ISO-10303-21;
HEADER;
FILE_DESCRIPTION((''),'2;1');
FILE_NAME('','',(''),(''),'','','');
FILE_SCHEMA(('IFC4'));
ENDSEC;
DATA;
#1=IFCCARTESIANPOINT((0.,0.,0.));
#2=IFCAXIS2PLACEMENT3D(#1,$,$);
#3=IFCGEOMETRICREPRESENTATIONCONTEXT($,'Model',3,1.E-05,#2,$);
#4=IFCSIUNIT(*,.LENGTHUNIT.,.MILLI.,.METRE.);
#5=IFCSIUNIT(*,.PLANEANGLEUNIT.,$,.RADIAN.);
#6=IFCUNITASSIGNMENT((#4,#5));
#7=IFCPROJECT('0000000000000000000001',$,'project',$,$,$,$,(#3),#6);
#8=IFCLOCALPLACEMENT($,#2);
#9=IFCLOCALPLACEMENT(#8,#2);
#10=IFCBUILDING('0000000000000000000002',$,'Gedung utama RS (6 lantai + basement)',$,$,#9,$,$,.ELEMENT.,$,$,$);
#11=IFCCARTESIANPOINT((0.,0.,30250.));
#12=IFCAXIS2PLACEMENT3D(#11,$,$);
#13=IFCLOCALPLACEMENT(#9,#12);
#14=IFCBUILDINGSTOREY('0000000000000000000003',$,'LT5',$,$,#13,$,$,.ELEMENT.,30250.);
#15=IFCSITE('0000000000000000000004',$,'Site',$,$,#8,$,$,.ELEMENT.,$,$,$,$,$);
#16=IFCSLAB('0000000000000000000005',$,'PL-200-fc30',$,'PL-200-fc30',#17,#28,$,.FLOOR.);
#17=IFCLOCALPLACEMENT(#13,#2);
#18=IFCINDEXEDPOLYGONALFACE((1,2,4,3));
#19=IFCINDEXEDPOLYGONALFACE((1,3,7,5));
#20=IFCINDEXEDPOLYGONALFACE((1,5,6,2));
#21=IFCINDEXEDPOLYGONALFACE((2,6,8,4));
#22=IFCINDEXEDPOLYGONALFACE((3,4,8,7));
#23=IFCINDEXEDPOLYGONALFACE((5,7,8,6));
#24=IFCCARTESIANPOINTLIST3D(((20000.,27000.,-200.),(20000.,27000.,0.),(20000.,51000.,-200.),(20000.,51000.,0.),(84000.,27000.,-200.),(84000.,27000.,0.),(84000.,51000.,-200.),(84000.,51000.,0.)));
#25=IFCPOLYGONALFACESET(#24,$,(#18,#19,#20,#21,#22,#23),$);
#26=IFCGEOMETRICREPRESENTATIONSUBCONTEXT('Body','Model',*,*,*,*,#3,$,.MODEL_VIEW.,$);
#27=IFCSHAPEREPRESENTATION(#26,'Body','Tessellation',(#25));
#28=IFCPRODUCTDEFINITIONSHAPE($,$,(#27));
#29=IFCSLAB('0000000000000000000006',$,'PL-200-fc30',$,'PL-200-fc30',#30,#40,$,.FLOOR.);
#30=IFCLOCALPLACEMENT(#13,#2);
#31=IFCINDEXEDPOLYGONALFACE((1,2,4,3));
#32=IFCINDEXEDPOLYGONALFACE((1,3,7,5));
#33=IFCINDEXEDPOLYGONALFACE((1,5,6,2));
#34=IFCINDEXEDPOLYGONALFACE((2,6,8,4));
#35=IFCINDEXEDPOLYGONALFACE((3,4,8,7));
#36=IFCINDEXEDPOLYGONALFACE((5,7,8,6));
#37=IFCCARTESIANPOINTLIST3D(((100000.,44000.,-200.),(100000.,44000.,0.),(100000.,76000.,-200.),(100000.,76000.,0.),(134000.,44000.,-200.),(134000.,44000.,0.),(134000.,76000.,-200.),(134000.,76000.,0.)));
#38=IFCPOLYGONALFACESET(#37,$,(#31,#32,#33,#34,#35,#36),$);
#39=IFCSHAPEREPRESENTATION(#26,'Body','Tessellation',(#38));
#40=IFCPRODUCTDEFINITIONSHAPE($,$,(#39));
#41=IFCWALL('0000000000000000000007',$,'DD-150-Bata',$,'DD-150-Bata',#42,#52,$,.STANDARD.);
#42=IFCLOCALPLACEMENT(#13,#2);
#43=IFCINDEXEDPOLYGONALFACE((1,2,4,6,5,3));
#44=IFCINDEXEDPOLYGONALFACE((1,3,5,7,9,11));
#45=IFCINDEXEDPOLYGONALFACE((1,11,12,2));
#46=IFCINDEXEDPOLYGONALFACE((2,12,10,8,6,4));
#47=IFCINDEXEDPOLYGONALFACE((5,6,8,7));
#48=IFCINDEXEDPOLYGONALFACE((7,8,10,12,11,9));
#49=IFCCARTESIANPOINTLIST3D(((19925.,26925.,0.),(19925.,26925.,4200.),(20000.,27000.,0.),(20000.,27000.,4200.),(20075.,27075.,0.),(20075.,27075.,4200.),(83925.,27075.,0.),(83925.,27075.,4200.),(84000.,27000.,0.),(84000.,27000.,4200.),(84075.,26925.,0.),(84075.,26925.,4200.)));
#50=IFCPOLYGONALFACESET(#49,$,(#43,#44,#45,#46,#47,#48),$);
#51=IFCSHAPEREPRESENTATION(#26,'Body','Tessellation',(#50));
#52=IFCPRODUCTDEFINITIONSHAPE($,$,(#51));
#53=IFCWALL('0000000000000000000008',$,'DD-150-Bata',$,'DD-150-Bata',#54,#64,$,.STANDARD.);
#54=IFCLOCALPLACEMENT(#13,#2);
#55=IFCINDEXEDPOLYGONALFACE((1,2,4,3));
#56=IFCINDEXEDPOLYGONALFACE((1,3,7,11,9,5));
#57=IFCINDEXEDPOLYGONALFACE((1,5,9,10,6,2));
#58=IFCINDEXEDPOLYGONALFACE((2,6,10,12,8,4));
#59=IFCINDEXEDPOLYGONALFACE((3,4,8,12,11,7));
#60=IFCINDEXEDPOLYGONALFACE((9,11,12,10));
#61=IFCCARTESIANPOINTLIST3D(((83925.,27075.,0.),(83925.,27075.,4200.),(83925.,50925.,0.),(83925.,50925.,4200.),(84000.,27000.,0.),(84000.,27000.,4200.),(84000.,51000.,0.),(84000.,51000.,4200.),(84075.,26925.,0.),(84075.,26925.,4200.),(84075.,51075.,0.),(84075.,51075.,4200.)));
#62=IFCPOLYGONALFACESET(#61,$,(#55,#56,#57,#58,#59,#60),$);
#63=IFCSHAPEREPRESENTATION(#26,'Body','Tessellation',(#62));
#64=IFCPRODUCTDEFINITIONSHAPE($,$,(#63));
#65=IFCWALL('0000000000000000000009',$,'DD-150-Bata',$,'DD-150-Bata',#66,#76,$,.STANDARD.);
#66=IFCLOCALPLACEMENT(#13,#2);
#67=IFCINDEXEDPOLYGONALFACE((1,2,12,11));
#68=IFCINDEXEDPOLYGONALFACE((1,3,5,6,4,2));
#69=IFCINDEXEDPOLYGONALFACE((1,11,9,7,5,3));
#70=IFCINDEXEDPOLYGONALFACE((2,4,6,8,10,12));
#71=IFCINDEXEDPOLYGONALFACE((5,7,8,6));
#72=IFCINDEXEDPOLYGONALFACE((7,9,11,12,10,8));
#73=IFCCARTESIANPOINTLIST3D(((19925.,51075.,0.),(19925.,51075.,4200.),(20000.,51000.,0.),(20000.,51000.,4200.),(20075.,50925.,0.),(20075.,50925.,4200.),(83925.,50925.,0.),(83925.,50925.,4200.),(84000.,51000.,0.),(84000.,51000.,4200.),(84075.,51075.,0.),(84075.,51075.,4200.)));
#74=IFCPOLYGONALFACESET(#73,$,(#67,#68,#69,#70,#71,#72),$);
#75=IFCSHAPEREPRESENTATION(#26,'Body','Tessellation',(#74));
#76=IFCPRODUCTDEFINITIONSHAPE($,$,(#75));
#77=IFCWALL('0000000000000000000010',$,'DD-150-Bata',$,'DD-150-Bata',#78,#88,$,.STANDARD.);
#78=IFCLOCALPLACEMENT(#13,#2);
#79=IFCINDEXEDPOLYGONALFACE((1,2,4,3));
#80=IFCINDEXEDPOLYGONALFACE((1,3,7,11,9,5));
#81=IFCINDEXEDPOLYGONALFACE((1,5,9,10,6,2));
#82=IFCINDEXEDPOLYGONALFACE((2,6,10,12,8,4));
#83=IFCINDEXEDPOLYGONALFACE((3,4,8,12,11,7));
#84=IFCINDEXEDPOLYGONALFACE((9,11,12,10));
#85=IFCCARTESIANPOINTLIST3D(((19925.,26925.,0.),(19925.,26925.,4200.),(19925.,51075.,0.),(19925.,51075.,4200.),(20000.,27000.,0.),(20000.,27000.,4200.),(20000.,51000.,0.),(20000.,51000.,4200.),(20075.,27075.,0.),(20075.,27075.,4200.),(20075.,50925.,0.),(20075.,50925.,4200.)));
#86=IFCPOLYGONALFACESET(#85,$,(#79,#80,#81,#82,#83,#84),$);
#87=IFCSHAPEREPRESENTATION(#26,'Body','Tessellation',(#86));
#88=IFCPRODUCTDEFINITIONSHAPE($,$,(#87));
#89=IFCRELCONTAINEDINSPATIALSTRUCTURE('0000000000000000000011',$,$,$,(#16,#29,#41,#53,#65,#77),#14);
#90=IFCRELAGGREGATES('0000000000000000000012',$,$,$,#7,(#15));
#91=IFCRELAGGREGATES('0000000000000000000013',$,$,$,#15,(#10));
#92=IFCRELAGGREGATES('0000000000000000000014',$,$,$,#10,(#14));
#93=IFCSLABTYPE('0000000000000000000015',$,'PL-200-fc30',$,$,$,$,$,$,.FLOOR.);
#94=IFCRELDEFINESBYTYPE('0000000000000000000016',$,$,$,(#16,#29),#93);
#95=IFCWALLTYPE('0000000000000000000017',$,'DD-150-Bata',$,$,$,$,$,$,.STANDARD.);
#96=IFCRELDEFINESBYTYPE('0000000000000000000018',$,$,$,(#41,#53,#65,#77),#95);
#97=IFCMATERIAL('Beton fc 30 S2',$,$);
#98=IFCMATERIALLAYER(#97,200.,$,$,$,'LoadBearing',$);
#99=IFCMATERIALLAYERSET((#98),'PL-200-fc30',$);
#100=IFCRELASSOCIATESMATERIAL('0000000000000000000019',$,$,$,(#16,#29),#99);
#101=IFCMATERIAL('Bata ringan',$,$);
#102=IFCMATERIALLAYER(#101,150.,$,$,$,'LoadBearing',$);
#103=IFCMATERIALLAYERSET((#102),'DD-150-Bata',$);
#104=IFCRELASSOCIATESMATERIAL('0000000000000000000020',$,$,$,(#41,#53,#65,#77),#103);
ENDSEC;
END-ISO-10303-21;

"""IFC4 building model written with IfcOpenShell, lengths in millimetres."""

from ifc_helpers import new_model, si_unit, frame, origin, place, context, subcontext, project, spatial, polyline, outline, extrude, material, layer, layer_set, layer_usage, type_object, element, save


model = new_model("IFC4")

# Units and contexts
model_context = context("Model", 3, precision=1e-05, world=origin())
body_context = subcontext(model_context, "Body", "Model", "MODEL_VIEW")
ifc_project = project(units=[si_unit("LENGTHUNIT", "METRE", prefix="MILLI"), si_unit("PLANEANGLEUNIT", "RADIAN")], contexts=[model_context])

# Site, building, storey
site_placement = place(None, origin())
site = spatial("IfcSite", under=ifc_project, at=site_placement, Name="Site", CompositionType="ELEMENT")
building_placement = place(site_placement, origin())
building = spatial("IfcBuilding", under=site, at=building_placement, Name="Gedung utama RS (6 lantai + basement)", CompositionType="ELEMENT")
storey_placement = place(building_placement, frame((0.0, 0.0, 30250.0)))
storey = spatial("IfcBuildingStorey", under=building, at=storey_placement, Name="LT5", CompositionType="ELEMENT", Elevation=30250.0)

# Slabs
ifc_material_1 = material(Name="Beton fc 30 S2")
ifc_layer_1 = layer(ifc_material_1, 200.0, Category="LoadBearing")
ifc_layer_set_1 = layer_set([ifc_layer_1], Name="PL-200-fc30")
ifc_layer_usage_1 = layer_usage(ifc_layer_set_1, "AXIS3", "NEGATIVE", 0.0)
slab_type = type_object("IfcSlabType", Name="PL-200-fc30", PredefinedType="FLOOR")
slab_1_placement = place(storey_placement, origin())
element("IfcSlab", 1, at=slab_1_placement, inside=storey, type_object=slab_type, material=ifc_layer_usage_1, Name="PL-200-fc30", ObjectType="PL-200-fc30", PredefinedType="FLOOR", context=body_context, shape_type="SweptSolid", body=[
    extrude(outline(polyline([(20000.0, 27000.0), (84000.0, 27000.0), (84000.0, 51000.0), (20000.0, 51000.0), (20000.0, 27000.0)])), frame((0.0, 0.0, -200.0)), (0.0, 0.0, 1.0), 200.0),
])
slab_2_placement = place(storey_placement, origin())
element("IfcSlab", 2, at=slab_2_placement, inside=storey, type_object=slab_type, material=ifc_layer_usage_1, Name="PL-200-fc30", ObjectType="PL-200-fc30", PredefinedType="FLOOR", context=body_context, shape_type="SweptSolid", body=[
    extrude(outline(polyline([(100000.0, 44000.0), (134000.0, 44000.0), (134000.0, 76000.0), (100000.0, 76000.0), (100000.0, 44000.0)])), frame((0.0, 0.0, -200.0)), (0.0, 0.0, 1.0), 200.0),
])

# Walls
ifc_material_2 = material(Name="Bata ringan")
ifc_layer_2 = layer(ifc_material_2, 150.0, Category="LoadBearing")
ifc_layer_set_2 = layer_set([ifc_layer_2], Name="DD-150-Bata")
ifc_layer_usage_2 = layer_usage(ifc_layer_set_2, "AXIS2", "NEGATIVE", 75.0)
wall_type = type_object("IfcWallType", Name="DD-150-Bata", PredefinedType="STANDARD")
wall_1_placement = place(storey_placement, frame((20000.0, 27000.0, 0.0), z_axis=(0.0, 0.0, 1.0), x_axis=(1.0, 0.0, 0.0)))
element("IfcWall", 3, at=wall_1_placement, inside=storey, type_object=wall_type, material=ifc_layer_usage_2, Name="DD-150-Bata", ObjectType="DD-150-Bata", PredefinedType="STANDARD", context=body_context, shape_type="SweptSolid", body=[
    extrude(outline(polyline([(-75.0, -75.0), (0.0, 0.0), (75.0, 75.0), (63925.0, 75.0), (64000.0, 0.0), (64075.0, -75.0), (-75.0, -75.0)])), origin(), (0.0, 0.0, 1.0), 4200.0),
])
wall_2_placement = place(storey_placement, frame((84000.0, 27000.0, 0.0), z_axis=(0.0, 0.0, 1.0), x_axis=(0.0, 1.0, 0.0)))
element("IfcWall", 4, at=wall_2_placement, inside=storey, type_object=wall_type, material=ifc_layer_usage_2, Name="DD-150-Bata", ObjectType="DD-150-Bata", PredefinedType="STANDARD", context=body_context, shape_type="SweptSolid", body=[
    extrude(outline(polyline([(-75.0, -75.0), (0.0, 0.0), (75.0, 75.0), (23925.0, 75.0), (24000.0, 0.0), (24075.0, -75.0), (-75.0, -75.0)])), origin(), (0.0, 0.0, 1.0), 4200.0),
])
wall_3_placement = place(storey_placement, frame((84000.0, 51000.0, 0.0), z_axis=(0.0, 0.0, 1.0), x_axis=(-1.0, 0.0, 0.0)))
element("IfcWall", 5, at=wall_3_placement, inside=storey, type_object=wall_type, material=ifc_layer_usage_2, Name="DD-150-Bata", ObjectType="DD-150-Bata", PredefinedType="STANDARD", context=body_context, shape_type="SweptSolid", body=[
    extrude(outline(polyline([(-75.0, -75.0), (0.0, 0.0), (75.0, 75.0), (63925.0, 75.0), (64000.0, 0.0), (64075.0, -75.0), (-75.0, -75.0)])), origin(), (0.0, 0.0, 1.0), 4200.0),
])
wall_4_placement = place(storey_placement, frame((20000.0, 51000.0, 0.0), z_axis=(0.0, 0.0, 1.0), x_axis=(0.0, -1.0, 0.0)))
element("IfcWall", 6, at=wall_4_placement, inside=storey, type_object=wall_type, material=ifc_layer_usage_2, Name="DD-150-Bata", ObjectType="DD-150-Bata", PredefinedType="STANDARD", context=body_context, shape_type="SweptSolid", body=[
    extrude(outline(polyline([(-75.0, -75.0), (0.0, 0.0), (75.0, 75.0), (23925.0, 75.0), (24000.0, 0.0), (24075.0, -75.0), (-75.0, -75.0)])), origin(), (0.0, 0.0, 1.0), 4200.0),
])

save(model, "model.ifc")
